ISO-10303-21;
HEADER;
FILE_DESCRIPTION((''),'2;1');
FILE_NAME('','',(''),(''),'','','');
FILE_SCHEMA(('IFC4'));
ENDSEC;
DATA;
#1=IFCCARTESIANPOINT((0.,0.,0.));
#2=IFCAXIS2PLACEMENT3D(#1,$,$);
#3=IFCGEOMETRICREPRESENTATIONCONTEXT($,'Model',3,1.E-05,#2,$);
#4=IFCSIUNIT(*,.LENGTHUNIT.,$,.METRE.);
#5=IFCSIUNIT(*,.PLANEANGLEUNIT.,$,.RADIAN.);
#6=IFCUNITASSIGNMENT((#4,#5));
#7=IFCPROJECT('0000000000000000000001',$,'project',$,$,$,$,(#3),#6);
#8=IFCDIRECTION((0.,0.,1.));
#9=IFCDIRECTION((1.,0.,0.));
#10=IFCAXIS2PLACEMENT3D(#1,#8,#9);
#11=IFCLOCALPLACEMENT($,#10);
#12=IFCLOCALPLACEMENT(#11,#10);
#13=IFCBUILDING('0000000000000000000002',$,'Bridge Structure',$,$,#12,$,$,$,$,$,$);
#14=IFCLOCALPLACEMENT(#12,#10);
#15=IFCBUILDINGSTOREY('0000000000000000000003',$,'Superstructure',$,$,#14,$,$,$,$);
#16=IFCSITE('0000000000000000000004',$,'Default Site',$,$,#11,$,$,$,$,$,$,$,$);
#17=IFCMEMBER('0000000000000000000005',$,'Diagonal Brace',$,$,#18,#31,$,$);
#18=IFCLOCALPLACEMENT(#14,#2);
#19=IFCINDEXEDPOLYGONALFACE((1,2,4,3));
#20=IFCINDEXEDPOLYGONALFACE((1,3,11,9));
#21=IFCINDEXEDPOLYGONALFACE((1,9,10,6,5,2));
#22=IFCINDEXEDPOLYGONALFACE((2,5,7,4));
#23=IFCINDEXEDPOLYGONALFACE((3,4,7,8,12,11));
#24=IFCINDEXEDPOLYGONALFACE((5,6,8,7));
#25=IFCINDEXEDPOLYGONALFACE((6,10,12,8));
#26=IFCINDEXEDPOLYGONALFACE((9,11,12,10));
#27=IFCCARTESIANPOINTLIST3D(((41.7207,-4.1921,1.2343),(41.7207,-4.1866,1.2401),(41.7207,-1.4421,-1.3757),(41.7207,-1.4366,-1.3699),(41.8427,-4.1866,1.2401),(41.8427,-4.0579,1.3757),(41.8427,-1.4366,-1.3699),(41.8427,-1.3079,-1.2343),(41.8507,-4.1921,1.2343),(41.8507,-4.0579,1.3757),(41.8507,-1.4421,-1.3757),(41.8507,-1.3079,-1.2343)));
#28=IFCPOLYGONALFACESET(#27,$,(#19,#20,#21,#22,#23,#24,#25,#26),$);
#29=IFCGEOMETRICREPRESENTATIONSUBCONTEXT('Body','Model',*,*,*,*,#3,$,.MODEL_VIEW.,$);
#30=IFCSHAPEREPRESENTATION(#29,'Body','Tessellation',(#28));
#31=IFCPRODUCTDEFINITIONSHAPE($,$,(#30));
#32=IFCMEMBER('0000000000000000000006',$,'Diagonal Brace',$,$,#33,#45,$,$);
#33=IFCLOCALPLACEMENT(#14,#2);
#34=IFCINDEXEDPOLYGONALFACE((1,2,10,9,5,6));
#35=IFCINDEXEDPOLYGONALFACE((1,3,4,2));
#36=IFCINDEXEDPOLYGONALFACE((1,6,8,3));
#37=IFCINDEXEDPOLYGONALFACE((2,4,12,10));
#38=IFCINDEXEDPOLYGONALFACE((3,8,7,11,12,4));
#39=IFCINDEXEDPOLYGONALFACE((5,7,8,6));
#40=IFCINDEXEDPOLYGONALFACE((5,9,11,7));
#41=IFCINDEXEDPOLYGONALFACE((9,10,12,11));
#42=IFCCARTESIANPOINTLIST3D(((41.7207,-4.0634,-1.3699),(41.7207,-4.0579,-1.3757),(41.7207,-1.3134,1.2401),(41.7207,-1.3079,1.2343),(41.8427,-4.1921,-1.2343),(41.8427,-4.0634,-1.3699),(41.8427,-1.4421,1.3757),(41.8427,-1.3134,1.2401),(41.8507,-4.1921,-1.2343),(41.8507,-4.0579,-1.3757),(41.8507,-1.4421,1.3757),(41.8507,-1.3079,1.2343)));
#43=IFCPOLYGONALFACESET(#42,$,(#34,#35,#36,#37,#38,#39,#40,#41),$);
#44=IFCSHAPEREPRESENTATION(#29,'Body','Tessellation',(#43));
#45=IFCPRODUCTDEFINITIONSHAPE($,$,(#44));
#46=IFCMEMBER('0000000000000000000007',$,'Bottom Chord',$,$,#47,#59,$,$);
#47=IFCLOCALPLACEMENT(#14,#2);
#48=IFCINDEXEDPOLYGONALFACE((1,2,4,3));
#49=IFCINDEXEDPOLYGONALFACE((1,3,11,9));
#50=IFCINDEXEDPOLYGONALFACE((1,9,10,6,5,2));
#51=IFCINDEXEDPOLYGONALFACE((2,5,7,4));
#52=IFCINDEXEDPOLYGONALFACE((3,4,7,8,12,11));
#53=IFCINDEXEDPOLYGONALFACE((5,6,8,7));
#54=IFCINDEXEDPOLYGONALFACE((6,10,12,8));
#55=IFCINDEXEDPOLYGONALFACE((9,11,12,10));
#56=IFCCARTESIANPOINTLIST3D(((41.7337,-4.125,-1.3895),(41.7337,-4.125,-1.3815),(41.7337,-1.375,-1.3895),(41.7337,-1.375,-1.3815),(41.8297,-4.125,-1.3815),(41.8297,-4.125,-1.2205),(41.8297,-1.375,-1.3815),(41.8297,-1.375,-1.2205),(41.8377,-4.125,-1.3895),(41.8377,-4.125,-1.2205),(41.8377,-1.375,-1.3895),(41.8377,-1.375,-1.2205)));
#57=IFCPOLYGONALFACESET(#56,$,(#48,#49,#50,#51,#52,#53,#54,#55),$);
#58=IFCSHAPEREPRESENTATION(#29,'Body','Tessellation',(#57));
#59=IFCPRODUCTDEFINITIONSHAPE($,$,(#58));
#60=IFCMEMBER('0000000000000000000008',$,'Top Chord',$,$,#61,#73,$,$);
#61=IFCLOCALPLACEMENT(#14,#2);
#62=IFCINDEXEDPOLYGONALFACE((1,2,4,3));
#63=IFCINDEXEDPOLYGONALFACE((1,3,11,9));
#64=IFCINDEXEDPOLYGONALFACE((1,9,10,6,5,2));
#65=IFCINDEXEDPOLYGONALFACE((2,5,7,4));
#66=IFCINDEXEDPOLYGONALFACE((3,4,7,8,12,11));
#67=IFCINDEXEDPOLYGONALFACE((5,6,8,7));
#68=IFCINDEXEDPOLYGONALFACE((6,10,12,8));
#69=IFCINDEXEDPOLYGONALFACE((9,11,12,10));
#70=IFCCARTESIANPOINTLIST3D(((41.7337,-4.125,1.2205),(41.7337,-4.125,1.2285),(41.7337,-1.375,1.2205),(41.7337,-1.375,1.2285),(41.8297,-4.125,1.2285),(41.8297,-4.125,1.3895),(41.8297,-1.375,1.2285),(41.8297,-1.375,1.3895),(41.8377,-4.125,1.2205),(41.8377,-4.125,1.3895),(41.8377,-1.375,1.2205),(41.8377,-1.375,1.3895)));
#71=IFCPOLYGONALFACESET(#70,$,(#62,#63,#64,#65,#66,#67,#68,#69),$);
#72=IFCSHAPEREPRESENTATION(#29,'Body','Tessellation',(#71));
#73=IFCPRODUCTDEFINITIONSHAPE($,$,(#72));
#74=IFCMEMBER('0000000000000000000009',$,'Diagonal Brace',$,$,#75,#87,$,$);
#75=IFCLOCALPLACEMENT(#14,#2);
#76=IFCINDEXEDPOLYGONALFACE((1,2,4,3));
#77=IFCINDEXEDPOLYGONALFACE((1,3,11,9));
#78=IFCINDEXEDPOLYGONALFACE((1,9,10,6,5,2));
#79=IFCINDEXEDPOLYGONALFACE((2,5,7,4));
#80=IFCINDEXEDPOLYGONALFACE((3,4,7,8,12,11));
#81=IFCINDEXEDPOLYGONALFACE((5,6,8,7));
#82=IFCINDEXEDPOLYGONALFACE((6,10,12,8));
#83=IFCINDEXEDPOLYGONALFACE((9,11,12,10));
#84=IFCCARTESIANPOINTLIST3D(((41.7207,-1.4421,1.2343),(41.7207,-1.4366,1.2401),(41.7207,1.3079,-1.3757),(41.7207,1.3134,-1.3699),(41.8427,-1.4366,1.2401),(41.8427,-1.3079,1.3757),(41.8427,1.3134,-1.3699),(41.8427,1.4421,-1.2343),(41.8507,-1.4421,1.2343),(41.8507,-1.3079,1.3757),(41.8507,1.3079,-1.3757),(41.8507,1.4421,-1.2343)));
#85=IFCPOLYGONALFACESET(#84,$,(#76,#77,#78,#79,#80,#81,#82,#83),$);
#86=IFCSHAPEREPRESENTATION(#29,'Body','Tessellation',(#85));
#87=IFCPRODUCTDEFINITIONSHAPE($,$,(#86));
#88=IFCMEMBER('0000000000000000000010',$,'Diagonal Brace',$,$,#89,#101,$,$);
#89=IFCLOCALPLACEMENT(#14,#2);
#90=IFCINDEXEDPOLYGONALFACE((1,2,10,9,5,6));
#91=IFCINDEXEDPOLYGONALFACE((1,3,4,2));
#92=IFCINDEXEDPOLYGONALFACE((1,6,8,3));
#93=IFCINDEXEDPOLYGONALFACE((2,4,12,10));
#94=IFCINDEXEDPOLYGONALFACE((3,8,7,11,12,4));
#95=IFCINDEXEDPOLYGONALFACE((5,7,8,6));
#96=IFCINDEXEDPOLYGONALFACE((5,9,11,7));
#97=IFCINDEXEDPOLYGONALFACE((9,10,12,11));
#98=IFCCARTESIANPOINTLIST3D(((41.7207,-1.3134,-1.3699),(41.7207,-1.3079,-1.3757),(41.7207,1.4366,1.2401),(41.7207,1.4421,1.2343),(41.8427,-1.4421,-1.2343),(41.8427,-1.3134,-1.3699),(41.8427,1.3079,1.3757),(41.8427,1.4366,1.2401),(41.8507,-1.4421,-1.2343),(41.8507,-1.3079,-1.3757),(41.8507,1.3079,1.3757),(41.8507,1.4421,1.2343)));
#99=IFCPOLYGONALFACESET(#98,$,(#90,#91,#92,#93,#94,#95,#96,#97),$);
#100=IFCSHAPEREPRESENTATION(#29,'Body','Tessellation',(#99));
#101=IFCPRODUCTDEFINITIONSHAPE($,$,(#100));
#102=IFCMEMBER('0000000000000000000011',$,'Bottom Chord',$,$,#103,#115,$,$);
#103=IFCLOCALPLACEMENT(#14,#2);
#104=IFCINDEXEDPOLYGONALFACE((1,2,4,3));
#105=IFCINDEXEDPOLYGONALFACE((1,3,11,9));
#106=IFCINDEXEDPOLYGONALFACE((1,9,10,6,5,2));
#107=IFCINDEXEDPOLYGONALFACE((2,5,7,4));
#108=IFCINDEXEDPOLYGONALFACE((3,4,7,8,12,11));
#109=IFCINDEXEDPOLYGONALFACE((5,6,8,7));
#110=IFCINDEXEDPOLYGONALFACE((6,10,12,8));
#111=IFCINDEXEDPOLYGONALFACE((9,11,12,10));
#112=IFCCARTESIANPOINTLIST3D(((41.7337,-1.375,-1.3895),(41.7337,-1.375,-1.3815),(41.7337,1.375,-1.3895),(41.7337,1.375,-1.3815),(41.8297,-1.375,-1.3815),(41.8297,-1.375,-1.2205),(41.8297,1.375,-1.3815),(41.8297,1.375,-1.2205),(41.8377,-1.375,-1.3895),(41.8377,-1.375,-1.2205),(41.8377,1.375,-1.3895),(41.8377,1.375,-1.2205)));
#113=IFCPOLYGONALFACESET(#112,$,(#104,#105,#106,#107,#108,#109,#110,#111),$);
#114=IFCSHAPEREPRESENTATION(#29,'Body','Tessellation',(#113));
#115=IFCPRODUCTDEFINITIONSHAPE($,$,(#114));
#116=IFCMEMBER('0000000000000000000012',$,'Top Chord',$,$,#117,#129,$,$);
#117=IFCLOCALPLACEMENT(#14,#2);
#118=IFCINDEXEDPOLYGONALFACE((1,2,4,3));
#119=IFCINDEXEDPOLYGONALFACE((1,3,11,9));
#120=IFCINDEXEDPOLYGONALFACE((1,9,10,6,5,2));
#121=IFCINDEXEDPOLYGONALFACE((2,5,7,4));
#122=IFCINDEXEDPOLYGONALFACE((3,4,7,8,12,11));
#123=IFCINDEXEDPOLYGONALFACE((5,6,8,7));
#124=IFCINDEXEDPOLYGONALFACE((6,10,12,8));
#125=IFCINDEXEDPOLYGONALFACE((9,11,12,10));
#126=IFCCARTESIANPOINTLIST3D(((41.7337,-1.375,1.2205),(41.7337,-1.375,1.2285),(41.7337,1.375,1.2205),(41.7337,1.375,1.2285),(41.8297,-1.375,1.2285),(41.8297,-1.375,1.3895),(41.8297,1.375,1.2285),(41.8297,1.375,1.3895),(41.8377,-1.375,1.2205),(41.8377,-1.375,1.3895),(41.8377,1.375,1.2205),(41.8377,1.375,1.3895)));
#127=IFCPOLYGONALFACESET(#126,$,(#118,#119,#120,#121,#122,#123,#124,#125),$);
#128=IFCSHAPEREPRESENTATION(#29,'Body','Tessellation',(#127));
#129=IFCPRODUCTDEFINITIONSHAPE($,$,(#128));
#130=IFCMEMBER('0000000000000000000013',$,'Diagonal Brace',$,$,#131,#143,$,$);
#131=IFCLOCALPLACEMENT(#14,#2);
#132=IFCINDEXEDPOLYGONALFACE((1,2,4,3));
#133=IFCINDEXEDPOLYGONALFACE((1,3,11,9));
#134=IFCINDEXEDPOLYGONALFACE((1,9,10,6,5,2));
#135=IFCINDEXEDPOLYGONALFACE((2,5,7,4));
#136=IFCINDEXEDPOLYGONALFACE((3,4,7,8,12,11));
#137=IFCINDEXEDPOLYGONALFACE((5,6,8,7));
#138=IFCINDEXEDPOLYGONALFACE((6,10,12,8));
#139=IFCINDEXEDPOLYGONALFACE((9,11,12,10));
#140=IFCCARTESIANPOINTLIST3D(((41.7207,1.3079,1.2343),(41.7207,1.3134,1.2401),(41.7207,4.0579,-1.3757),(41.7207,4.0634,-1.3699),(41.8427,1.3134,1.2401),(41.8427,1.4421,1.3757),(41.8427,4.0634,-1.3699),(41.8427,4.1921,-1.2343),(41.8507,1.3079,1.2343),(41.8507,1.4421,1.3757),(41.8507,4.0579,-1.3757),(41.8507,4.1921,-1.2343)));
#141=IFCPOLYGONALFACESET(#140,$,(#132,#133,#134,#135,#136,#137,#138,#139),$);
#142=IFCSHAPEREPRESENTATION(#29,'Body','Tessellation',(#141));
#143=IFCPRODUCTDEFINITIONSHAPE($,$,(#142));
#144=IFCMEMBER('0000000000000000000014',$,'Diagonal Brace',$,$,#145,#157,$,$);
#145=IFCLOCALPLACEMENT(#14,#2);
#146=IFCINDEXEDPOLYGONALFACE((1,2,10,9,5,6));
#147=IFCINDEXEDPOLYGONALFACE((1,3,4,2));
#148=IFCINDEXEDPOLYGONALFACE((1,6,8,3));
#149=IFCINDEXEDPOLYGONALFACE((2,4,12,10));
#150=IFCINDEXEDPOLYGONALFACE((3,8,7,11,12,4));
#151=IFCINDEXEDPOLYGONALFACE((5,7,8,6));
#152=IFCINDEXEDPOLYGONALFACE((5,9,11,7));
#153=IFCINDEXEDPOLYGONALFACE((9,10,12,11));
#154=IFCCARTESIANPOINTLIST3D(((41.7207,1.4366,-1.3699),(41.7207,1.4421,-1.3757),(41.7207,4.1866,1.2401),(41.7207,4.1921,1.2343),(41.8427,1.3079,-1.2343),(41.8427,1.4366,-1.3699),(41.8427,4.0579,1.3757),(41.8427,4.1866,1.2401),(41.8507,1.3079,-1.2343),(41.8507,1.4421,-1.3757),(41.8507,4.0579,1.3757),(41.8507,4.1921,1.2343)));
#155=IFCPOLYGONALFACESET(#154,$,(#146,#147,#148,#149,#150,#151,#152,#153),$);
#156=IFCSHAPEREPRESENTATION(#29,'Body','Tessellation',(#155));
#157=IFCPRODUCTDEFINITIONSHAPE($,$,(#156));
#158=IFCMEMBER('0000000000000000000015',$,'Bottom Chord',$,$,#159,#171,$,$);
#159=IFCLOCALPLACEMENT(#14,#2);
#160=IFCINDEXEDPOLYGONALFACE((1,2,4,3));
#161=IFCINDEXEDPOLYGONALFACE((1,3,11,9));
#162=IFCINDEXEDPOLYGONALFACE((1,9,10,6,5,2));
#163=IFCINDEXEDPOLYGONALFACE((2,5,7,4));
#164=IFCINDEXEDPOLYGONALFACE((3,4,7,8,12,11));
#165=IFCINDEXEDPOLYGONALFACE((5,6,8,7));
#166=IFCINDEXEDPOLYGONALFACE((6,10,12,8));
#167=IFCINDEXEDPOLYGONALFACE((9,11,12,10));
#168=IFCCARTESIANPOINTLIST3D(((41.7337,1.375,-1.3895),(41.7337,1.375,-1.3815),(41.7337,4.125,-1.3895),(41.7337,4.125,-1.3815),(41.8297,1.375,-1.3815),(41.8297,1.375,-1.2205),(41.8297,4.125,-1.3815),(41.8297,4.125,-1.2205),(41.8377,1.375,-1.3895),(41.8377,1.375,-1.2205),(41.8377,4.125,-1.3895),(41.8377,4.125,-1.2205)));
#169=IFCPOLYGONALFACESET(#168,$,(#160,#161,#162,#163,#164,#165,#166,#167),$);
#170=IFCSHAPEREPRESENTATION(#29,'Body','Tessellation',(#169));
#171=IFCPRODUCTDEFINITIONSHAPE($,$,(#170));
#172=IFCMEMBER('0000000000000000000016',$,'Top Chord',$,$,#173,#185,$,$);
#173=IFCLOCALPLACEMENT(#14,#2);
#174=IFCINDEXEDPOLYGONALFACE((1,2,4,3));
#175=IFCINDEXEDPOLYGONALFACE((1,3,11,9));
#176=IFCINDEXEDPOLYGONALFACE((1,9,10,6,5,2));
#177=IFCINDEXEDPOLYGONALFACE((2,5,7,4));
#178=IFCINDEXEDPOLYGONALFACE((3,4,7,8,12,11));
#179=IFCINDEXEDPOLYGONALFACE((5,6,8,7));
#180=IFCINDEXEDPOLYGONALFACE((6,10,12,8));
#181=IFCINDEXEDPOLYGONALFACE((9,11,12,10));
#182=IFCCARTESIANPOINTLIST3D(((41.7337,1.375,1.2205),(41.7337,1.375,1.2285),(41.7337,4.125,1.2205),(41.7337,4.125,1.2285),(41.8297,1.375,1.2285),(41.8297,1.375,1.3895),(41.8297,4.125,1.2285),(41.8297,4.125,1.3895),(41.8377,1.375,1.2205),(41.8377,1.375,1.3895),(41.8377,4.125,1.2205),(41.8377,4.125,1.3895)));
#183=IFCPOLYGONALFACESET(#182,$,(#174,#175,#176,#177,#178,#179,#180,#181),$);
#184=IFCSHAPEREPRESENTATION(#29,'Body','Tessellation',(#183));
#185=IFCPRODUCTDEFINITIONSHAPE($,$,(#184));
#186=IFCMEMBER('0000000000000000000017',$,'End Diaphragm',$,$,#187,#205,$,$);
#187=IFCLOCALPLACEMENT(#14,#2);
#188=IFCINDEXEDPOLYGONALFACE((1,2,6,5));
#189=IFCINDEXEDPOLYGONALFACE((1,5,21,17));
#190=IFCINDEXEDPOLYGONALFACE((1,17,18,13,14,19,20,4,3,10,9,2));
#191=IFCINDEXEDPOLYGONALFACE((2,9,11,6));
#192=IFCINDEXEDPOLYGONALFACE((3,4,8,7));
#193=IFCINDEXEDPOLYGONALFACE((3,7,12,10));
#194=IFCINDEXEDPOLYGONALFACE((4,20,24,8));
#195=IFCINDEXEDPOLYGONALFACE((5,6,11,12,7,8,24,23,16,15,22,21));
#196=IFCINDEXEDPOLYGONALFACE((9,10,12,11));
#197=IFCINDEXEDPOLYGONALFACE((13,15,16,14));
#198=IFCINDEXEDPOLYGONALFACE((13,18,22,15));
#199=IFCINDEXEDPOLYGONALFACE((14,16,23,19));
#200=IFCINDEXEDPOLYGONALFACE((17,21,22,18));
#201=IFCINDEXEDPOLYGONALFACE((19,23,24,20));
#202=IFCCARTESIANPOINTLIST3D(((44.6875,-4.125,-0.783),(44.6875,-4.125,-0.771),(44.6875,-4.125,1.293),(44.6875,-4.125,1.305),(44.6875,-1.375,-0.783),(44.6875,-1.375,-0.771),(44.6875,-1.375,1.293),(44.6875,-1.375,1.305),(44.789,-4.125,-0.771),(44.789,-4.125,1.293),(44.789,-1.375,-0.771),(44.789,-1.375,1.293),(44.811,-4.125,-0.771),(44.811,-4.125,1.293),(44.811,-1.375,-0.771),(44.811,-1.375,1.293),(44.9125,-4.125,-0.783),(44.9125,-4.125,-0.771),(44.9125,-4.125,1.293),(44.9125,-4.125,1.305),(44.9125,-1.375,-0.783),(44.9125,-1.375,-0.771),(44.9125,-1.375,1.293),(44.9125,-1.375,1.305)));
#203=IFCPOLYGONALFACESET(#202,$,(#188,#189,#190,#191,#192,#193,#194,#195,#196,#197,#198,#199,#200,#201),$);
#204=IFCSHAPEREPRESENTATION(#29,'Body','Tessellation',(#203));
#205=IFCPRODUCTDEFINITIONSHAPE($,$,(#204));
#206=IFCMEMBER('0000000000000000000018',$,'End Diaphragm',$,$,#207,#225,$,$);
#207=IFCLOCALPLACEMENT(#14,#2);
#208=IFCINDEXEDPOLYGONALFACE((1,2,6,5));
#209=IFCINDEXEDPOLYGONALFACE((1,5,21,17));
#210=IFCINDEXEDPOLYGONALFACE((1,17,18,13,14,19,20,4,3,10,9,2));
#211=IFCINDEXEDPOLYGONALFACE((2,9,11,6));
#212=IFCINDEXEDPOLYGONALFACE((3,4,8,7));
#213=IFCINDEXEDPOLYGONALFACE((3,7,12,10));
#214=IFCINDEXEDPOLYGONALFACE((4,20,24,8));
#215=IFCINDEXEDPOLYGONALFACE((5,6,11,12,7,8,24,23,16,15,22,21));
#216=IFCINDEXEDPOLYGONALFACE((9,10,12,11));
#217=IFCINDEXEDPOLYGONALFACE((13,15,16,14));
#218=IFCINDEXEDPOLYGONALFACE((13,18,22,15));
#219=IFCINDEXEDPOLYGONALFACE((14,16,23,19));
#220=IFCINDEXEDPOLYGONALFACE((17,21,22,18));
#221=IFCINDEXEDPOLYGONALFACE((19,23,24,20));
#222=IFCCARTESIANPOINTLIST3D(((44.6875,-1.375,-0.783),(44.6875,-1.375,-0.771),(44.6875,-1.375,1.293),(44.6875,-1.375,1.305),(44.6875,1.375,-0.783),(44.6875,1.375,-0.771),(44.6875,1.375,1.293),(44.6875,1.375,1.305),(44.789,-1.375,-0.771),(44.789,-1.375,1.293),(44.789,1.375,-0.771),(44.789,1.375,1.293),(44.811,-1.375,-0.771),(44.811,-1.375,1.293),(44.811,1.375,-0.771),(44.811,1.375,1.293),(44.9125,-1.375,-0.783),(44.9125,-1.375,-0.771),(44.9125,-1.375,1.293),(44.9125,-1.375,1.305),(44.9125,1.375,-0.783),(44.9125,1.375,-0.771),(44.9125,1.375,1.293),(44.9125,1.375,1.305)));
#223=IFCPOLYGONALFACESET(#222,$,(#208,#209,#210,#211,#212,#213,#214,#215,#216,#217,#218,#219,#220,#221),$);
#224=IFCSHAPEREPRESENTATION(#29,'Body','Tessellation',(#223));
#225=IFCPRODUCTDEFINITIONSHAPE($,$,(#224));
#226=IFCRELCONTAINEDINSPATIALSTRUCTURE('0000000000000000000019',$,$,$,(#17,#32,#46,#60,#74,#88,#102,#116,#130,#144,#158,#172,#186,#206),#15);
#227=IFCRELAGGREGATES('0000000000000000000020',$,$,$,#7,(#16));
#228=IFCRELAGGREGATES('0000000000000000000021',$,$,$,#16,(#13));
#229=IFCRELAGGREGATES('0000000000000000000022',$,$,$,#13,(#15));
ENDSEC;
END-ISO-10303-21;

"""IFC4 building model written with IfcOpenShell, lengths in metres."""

from ifc_helpers import new_model, si_unit, frame, origin, origin_with_axes, origin_2d_with_axis, place, context, subcontext, project, spatial, i_section, l_section, extrude, element, save


model = new_model("IFC4")

# Units and contexts
model_context = context("Model", 3, precision=1e-05, world=origin())
body_context = subcontext(model_context, "Body", "Model", "MODEL_VIEW")
ifc_project = project(units=[si_unit("LENGTHUNIT", "METRE"), si_unit("PLANEANGLEUNIT", "RADIAN")], contexts=[model_context])

# Site, building, storey
site_placement = place(None, origin_with_axes())
site = spatial("IfcSite", under=ifc_project, at=site_placement, Name="Default Site")
building_placement = place(site_placement, origin_with_axes())
building = spatial("IfcBuilding", under=site, at=building_placement, Name="Bridge Structure")
storey_placement = place(building_placement, origin_with_axes())
storey = spatial("IfcBuildingStorey", under=building, at=storey_placement, Name="Superstructure")

# Members
for number, where, z_axis, x_axis, name in (
    (1, (41.7857, -4.125, 1.305), (0.0, 0.725329, -0.688403), (-1.0, 0.0, 0.0), "Diagonal Brace"),
    (2, (41.7857, -4.125, -1.305), (0.0, 0.725329, 0.688403), (-1.0, 0.0, 0.0), "Diagonal Brace"),
):
    element("IfcMember", number, at=place(storey_placement, frame(where, z_axis=z_axis, x_axis=x_axis)), inside=storey, Name=name, context=body_context, shape_type="SweptSolid", body=[
        extrude(l_section(Depth=0.195, Width=0.13, Thickness=0.008, at=origin_2d_with_axis()), origin_with_axes(), (0.0, 0.0, 1.0), 3.7914),
    ])
for number, where, z_axis, x_axis, name in (
    (3, (41.7857, -4.125, -1.305), (0.0, 1.0, 0.0), (-1.0, 0.0, 0.0), "Bottom Chord"),
    (4, (41.7857, -4.125, 1.305), (0.0, 1.0, 0.0), (-1.0, 0.0, 0.0), "Top Chord"),
):
    element("IfcMember", number, at=place(storey_placement, frame(where, z_axis=z_axis, x_axis=x_axis)), inside=storey, Name=name, context=body_context, shape_type="SweptSolid", body=[
        extrude(l_section(Depth=0.169, Width=0.104, Thickness=0.008, at=origin_2d_with_axis()), origin_with_axes(), (0.0, 0.0, 1.0), 2.75),
    ])
for number, where, z_axis, x_axis, name in (
    (5, (41.7857, -1.375, 1.305), (0.0, 0.725329, -0.688403), (-1.0, 0.0, 0.0), "Diagonal Brace"),
    (6, (41.7857, -1.375, -1.305), (0.0, 0.725329, 0.688403), (-1.0, 0.0, 0.0), "Diagonal Brace"),
):
    element("IfcMember", number, at=place(storey_placement, frame(where, z_axis=z_axis, x_axis=x_axis)), inside=storey, Name=name, context=body_context, shape_type="SweptSolid", body=[
        extrude(l_section(Depth=0.195, Width=0.13, Thickness=0.008, at=origin_2d_with_axis()), origin_with_axes(), (0.0, 0.0, 1.0), 3.7914),
    ])
for number, where, z_axis, x_axis, name in (
    (7, (41.7857, -1.375, -1.305), (0.0, 1.0, 0.0), (-1.0, 0.0, 0.0), "Bottom Chord"),
    (8, (41.7857, -1.375, 1.305), (0.0, 1.0, 0.0), (-1.0, 0.0, 0.0), "Top Chord"),
):
    element("IfcMember", number, at=place(storey_placement, frame(where, z_axis=z_axis, x_axis=x_axis)), inside=storey, Name=name, context=body_context, shape_type="SweptSolid", body=[
        extrude(l_section(Depth=0.169, Width=0.104, Thickness=0.008, at=origin_2d_with_axis()), origin_with_axes(), (0.0, 0.0, 1.0), 2.75),
    ])
for number, where, z_axis, x_axis, name in (
    (9, (41.7857, 1.375, 1.305), (0.0, 0.725329, -0.688403), (-1.0, 0.0, 0.0), "Diagonal Brace"),
    (10, (41.7857, 1.375, -1.305), (0.0, 0.725329, 0.688403), (-1.0, 0.0, 0.0), "Diagonal Brace"),
):
    element("IfcMember", number, at=place(storey_placement, frame(where, z_axis=z_axis, x_axis=x_axis)), inside=storey, Name=name, context=body_context, shape_type="SweptSolid", body=[
        extrude(l_section(Depth=0.195, Width=0.13, Thickness=0.008, at=origin_2d_with_axis()), origin_with_axes(), (0.0, 0.0, 1.0), 3.7914),
    ])
for number, where, z_axis, x_axis, name in (
    (11, (41.7857, 1.375, -1.305), (0.0, 1.0, 0.0), (-1.0, 0.0, 0.0), "Bottom Chord"),
    (12, (41.7857, 1.375, 1.305), (0.0, 1.0, 0.0), (-1.0, 0.0, 0.0), "Top Chord"),
):
    element("IfcMember", number, at=place(storey_placement, frame(where, z_axis=z_axis, x_axis=x_axis)), inside=storey, Name=name, context=body_context, shape_type="SweptSolid", body=[
        extrude(l_section(Depth=0.169, Width=0.104, Thickness=0.008, at=origin_2d_with_axis()), origin_with_axes(), (0.0, 0.0, 1.0), 2.75),
    ])
for number, where, z_axis, x_axis, name in (
    (13, (44.8, -4.125, 0.261), (0.0, 1.0, 0.0), (-1.0, 0.0, 0.0), "End Diaphragm"),
    (14, (44.8, -1.375, 0.261), (0.0, 1.0, 0.0), (-1.0, 0.0, 0.0), "End Diaphragm"),
):
    element("IfcMember", number, at=place(storey_placement, frame(where, z_axis=z_axis, x_axis=x_axis)), inside=storey, Name=name, context=body_context, shape_type="SweptSolid", body=[
        extrude(i_section(OverallWidth=0.225, OverallDepth=2.088, WebThickness=0.022, FlangeThickness=0.012, at=origin_2d_with_axis()), origin_with_axes(), (0.0, 0.0, 1.0), 2.75),
    ])

save(model, "model.ifc")
